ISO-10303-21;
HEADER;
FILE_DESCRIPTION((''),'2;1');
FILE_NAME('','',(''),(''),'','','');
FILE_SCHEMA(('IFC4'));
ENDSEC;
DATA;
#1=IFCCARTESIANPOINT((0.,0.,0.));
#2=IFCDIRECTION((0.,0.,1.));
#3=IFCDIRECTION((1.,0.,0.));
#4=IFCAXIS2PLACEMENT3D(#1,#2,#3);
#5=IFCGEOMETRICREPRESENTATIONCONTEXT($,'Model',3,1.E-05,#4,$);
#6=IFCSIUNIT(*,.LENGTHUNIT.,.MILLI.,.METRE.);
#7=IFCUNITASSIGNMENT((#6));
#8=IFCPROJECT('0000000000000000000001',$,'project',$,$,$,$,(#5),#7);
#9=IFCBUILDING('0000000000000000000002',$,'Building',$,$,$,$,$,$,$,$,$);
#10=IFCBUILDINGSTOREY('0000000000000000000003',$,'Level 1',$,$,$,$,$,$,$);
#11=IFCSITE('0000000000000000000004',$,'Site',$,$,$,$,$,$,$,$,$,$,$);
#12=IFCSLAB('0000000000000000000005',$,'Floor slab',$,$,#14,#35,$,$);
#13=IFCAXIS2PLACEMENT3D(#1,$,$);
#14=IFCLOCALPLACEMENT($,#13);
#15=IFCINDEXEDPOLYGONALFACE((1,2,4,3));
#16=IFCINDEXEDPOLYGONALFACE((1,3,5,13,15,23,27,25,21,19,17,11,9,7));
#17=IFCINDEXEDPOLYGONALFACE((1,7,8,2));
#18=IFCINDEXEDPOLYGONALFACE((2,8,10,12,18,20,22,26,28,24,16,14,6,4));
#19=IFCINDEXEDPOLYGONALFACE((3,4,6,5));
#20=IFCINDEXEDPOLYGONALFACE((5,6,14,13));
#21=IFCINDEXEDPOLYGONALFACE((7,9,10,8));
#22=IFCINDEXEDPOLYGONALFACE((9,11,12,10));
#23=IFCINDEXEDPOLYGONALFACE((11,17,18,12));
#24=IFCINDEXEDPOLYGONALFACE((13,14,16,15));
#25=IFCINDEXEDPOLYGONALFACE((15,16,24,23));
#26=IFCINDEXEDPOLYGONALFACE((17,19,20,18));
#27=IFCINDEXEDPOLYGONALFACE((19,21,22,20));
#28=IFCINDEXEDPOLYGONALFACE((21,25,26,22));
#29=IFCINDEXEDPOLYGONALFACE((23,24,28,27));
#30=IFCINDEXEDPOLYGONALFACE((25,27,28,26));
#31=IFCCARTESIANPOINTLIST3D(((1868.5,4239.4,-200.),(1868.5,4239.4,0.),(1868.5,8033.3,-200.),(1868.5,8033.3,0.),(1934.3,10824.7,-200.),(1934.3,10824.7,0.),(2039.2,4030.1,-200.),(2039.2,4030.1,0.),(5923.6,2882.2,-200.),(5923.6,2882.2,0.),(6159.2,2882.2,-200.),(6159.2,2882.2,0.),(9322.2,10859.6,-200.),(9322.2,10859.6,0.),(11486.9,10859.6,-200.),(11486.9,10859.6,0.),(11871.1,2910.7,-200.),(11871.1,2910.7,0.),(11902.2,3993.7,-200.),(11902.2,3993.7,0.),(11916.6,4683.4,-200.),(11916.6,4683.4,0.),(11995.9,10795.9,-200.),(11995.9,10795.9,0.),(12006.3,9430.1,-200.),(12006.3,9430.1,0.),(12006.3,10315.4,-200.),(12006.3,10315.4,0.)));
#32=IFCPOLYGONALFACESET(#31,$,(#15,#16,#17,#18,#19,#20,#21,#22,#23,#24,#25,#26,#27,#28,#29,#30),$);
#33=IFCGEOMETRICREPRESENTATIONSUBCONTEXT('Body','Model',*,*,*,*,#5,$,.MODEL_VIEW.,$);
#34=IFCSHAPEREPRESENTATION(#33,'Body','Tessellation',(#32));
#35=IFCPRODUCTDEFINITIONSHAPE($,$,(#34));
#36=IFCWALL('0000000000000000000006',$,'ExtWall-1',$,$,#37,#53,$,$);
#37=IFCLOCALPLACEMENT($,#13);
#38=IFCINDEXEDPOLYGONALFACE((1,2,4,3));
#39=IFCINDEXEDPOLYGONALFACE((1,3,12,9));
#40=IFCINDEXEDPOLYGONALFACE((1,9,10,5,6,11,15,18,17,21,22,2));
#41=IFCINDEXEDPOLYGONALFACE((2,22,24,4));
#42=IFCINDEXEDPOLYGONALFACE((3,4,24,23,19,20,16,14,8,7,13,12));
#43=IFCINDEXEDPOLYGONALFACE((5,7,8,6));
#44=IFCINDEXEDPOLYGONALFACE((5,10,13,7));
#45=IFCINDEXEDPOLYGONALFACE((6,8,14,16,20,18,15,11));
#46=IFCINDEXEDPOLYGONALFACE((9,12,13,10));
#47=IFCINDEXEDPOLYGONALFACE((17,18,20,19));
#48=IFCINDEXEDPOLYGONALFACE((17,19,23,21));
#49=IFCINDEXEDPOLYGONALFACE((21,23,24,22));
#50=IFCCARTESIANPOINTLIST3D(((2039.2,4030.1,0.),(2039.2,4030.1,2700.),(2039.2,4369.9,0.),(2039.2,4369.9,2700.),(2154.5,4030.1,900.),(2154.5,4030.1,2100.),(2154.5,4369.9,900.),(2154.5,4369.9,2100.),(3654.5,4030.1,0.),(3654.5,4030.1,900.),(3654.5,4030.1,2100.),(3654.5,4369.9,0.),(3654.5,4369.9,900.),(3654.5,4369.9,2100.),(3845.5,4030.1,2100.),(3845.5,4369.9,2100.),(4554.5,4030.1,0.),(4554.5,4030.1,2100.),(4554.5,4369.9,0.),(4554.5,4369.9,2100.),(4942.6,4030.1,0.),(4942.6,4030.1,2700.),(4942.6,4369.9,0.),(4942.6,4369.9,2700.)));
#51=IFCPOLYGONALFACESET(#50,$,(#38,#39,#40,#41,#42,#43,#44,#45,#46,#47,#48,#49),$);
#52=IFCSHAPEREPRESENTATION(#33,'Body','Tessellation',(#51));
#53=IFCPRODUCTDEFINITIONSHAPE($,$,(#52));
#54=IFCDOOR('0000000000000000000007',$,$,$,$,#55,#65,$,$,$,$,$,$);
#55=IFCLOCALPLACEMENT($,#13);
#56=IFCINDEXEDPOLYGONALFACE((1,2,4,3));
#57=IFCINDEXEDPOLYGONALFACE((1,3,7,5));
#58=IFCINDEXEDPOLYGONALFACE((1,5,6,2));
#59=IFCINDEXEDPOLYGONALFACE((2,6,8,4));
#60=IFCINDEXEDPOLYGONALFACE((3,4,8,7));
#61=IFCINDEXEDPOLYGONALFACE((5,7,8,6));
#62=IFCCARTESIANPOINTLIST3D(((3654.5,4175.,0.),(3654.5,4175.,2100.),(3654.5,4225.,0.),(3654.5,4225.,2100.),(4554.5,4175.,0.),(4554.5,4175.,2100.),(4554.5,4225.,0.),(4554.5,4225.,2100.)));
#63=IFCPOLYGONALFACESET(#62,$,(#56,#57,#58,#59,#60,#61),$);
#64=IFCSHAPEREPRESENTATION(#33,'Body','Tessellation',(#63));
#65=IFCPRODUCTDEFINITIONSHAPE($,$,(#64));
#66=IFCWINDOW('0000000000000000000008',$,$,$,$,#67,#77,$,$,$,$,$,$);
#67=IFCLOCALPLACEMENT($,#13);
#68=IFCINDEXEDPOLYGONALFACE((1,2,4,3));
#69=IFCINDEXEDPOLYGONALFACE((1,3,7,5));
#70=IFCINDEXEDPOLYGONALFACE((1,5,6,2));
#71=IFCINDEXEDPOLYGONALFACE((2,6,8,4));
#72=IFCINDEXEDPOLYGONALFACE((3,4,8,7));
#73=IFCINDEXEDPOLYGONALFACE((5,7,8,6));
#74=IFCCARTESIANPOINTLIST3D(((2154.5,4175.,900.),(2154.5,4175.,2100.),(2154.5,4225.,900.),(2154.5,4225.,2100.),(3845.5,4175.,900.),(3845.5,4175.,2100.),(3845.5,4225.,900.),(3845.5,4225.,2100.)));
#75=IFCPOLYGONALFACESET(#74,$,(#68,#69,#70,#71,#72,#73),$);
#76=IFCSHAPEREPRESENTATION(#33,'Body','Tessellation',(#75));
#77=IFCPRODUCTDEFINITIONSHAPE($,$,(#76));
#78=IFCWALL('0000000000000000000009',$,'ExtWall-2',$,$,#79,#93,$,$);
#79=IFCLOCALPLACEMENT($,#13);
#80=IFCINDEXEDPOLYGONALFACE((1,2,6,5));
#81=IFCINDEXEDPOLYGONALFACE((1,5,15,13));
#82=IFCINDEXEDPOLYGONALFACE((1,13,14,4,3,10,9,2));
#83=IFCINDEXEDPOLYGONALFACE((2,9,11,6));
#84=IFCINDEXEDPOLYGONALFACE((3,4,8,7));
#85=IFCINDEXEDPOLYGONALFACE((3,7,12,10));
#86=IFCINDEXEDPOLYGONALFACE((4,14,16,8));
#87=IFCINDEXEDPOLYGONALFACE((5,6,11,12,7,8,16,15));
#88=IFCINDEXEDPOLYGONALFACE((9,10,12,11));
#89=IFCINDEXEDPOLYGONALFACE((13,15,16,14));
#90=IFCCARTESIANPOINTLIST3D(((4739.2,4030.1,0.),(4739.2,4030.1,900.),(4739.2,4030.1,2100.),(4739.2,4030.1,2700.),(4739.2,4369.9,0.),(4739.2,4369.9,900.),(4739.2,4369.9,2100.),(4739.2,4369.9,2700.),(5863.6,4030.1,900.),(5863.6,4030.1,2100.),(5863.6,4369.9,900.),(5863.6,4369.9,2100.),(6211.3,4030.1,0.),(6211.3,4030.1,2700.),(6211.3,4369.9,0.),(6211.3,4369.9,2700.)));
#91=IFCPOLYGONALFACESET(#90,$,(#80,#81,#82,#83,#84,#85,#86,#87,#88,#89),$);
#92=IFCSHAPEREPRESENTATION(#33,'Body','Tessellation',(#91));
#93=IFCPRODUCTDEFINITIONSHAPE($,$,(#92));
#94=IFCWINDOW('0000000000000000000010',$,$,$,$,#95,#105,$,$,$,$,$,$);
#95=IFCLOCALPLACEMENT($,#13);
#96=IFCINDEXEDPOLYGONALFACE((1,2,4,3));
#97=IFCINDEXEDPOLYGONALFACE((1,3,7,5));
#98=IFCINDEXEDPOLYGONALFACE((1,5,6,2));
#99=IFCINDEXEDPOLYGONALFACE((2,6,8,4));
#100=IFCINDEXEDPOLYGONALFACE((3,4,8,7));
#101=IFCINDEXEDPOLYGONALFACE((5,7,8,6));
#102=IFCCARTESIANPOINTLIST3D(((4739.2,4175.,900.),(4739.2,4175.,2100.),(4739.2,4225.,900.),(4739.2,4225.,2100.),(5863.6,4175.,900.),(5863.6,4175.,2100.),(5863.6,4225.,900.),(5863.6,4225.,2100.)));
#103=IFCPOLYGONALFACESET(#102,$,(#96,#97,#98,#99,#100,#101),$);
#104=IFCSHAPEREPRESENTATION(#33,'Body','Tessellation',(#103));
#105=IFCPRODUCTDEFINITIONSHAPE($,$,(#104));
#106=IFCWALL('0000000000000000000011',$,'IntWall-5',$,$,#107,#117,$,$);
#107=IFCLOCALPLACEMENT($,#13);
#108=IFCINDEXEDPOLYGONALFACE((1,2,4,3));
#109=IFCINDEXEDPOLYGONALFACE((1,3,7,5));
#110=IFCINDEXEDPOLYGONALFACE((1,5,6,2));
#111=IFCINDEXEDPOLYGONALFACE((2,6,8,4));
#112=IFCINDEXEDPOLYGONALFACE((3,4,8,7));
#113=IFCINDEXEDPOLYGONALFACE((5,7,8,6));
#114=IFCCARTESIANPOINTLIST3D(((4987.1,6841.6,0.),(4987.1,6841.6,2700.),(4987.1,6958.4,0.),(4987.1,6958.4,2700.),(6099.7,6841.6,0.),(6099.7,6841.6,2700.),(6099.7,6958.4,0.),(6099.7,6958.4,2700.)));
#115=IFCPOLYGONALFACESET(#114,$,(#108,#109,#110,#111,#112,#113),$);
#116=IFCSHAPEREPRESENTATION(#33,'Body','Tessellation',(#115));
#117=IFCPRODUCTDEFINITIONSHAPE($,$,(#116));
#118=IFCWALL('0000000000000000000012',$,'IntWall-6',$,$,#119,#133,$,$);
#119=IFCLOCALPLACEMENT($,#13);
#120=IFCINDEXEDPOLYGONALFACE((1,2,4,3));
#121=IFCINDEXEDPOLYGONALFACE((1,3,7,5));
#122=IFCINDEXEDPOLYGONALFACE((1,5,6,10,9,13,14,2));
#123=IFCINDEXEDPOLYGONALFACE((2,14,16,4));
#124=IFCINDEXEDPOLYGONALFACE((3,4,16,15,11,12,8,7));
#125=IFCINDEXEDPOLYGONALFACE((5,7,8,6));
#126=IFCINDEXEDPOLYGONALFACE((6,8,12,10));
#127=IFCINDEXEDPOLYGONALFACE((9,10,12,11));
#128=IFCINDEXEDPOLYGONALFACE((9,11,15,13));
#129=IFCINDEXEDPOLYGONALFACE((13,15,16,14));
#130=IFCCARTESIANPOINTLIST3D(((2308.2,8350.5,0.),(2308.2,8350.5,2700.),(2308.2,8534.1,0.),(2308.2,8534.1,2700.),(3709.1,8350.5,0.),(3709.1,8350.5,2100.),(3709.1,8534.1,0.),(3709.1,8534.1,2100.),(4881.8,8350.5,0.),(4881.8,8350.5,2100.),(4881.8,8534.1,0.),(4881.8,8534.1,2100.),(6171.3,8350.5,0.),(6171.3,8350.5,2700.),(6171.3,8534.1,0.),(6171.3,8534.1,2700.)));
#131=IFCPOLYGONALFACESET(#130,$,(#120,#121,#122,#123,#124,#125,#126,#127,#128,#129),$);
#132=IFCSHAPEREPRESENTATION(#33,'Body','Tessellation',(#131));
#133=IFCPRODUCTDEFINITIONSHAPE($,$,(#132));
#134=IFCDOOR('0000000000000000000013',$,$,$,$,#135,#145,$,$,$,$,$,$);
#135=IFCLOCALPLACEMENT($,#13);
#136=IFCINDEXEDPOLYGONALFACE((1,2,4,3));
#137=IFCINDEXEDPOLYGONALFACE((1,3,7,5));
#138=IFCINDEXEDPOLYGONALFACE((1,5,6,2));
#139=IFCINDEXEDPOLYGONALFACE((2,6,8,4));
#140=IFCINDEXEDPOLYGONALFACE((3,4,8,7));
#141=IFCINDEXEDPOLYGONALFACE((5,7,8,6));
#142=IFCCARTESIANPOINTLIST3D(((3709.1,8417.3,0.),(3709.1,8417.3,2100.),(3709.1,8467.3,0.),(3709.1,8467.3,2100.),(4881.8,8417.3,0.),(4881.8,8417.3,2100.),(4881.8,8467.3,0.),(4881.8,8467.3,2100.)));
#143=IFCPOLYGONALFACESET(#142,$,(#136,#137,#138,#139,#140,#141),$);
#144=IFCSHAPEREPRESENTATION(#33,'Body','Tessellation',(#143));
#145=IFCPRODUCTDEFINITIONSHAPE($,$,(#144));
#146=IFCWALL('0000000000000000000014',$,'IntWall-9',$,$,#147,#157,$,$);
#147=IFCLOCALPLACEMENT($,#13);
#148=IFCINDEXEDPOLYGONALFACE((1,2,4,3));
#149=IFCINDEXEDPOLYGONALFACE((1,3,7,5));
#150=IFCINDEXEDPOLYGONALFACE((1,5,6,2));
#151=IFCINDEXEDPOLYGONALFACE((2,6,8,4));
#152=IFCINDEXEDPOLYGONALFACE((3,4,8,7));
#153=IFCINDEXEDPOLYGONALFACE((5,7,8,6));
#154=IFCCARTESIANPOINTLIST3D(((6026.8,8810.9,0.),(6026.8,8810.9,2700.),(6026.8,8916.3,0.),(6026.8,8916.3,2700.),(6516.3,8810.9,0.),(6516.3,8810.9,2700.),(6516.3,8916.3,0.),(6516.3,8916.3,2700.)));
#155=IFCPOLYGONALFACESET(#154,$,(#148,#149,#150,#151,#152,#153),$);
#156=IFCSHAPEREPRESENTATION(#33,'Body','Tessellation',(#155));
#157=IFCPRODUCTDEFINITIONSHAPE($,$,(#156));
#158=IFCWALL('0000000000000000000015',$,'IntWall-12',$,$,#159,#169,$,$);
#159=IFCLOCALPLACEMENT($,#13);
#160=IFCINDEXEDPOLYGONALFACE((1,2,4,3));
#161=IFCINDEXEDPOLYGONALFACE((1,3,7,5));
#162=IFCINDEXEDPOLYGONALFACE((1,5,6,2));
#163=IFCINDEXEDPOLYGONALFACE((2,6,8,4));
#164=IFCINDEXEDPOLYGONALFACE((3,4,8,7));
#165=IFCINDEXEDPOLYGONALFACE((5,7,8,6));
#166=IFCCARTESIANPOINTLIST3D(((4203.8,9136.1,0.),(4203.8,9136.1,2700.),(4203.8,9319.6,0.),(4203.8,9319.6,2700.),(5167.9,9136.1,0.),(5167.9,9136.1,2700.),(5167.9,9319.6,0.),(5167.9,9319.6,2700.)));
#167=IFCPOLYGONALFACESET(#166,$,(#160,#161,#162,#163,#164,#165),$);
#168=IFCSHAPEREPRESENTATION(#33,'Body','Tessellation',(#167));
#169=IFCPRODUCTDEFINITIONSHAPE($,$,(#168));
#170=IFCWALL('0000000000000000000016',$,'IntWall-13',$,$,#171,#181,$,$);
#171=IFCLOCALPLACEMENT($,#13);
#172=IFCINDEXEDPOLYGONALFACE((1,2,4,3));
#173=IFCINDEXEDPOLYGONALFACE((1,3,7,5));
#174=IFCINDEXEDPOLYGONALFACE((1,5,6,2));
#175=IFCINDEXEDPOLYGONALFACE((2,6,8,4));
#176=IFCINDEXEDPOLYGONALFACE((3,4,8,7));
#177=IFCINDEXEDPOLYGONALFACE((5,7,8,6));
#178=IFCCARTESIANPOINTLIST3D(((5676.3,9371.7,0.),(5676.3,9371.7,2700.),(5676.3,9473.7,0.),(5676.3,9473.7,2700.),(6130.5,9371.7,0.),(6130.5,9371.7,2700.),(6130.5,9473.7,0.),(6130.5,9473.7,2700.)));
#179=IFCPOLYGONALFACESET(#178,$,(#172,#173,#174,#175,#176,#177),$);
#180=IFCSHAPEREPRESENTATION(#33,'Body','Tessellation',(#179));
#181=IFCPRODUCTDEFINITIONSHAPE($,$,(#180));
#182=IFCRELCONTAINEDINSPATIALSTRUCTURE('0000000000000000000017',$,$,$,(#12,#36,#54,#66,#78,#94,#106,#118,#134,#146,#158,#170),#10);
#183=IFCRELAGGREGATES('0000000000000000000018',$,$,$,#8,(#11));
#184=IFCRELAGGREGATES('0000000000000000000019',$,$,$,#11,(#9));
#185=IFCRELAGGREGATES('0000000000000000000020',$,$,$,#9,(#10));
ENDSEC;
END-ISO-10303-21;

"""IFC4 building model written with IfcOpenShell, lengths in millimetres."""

from ifc_helpers import new_model, si_unit, frame, origin_with_axes, place, context, subcontext, project, spatial, indexed_curve, outline, extrude, element, fill, save


model = new_model("IFC4")

# Units and contexts
model_context = context("Model", 3, precision=1e-05, world=origin_with_axes())
body_context = subcontext(model_context, "Body", "Model", "MODEL_VIEW")
ifc_project = project(units=[si_unit("LENGTHUNIT", "METRE", prefix="MILLI")], contexts=[model_context])

# Site, building, storey
site = spatial("IfcSite", under=ifc_project, Name="Site")
building = spatial("IfcBuilding", under=site, Name="Building")
storey = spatial("IfcBuildingStorey", under=building, Name="Level 1")

# Slab
slab_placement = place(None, frame((0.0, 0.0, -200.0), z_axis=(0.0, 0.0, 1.0), x_axis=(1.0, 0.0, 0.0)))
element("IfcSlab", 1, at=slab_placement, inside=storey, Name="Floor slab", context=body_context, shape_type="SweptSolid", body=[
    extrude(outline(indexed_curve([(5923.6, 2882.2), (2039.2, 4030.1), (1868.5, 4239.4), (1868.5, 8033.3), (1934.3, 10824.7), (9322.2, 10859.6), (11486.9, 10859.6), (11995.9, 10795.9), (12006.3, 10315.4), (12006.3, 9430.1), (11916.6, 4683.4), (11902.2, 3993.7), (11871.1, 2910.7), (6159.2, 2882.2)])), None, (0.0, 0.0, 1.0), 200.0),
])

# Wall, openings, door, window
wall_1_placement = place(None, frame((2039.2, 4200.0, 0.0), z_axis=(0.0, 0.0, 1.0), x_axis=(1.0, 0.0, 0.0)))
wall_1 = element("IfcWall", 2, at=wall_1_placement, inside=storey, Name="ExtWall-1", context=body_context, shape_type="SweptSolid", body=[
    extrude(outline(indexed_curve([(0.0, 0.0), (0.0, 339.8), (2903.5, 339.8), (2903.5, 0.0), (0.0, 0.0)], self_intersect=False)), frame((0.0, -169.9, 0.0), z_axis=(0.0, 0.0, 1.0), x_axis=(1.0, 0.0, 0.0)), (0.0, 0.0, 1.0), 2700.0),
])
opening_1_placement = place(wall_1_placement, frame((1615.4, 0.0, 0.0), z_axis=(0.0, 0.0, 1.0), x_axis=(1.0, 0.0, 0.0)))
opening_1 = element("IfcOpeningElement", 3, at=opening_1_placement, cuts=wall_1, context=body_context, shape_type="SweptSolid", body=[
    extrude(outline(indexed_curve([(0.0, 0.0), (0.0, 439.8), (900.0, 439.8), (900.0, 0.0), (0.0, 0.0)], self_intersect=False)), frame((0.0, -219.9, 0.0), z_axis=(0.0, 0.0, 1.0), x_axis=(1.0, 0.0, 0.0)), (0.0, 0.0, 1.0), 2100.0),
])
opening_2_placement = place(wall_1_placement, frame((115.4, 0.0, 900.0), z_axis=(0.0, 0.0, 1.0), x_axis=(1.0, 0.0, 0.0)))
opening_2 = element("IfcOpeningElement", 4, at=opening_2_placement, cuts=wall_1, context=body_context, shape_type="SweptSolid", body=[
    extrude(outline(indexed_curve([(0.0, 0.0), (0.0, 439.8), (1690.9, 439.8), (1690.9, 0.0), (0.0, 0.0)], self_intersect=False)), frame((0.0, -219.9, 0.0), z_axis=(0.0, 0.0, 1.0), x_axis=(1.0, 0.0, 0.0)), (0.0, 0.0, 1.0), 1200.0),
])
door_1_placement = place(opening_1_placement, origin_with_axes())
door_1 = element("IfcDoor", 5, at=door_1_placement, inside=storey, context=body_context, shape_type="SweptSolid", body=[
    extrude(outline(indexed_curve([(0.0, 0.0), (0.0, 50.0), (900.0, 50.0), (900.0, 0.0), (0.0, 0.0)], self_intersect=False)), frame((0.0, -25.0, 0.0), z_axis=(0.0, 0.0, 1.0), x_axis=(1.0, 0.0, 0.0)), (0.0, 0.0, 1.0), 2100.0),
])
fill(opening_1, door_1)
window_1_placement = place(opening_2_placement, frame((0.0, 0.0, 0.0), z_axis=(0.0, 0.0, 1.0), x_axis=(1.0, 0.0, 0.0)))
window_1 = element("IfcWindow", 6, at=window_1_placement, inside=storey, context=body_context, shape_type="SweptSolid", body=[
    extrude(outline(indexed_curve([(0.0, 0.0), (0.0, 50.0), (1690.9, 50.0), (1690.9, 0.0), (0.0, 0.0)], self_intersect=False)), frame((0.0, -25.0, 0.0), z_axis=(0.0, 0.0, 1.0), x_axis=(1.0, 0.0, 0.0)), (0.0, 0.0, 1.0), 1200.0),
])
fill(opening_2, window_1)

# Wall, opening, window
wall_2_placement = place(None, frame((4739.2, 4200.0, 0.0), z_axis=(0.0, 0.0, 1.0), x_axis=(1.0, 0.0, 0.0)))
wall_2 = element("IfcWall", 7, at=wall_2_placement, inside=storey, Name="ExtWall-2", context=body_context, shape_type="SweptSolid", body=[
    extrude(outline(indexed_curve([(0.0, 0.0), (0.0, 339.8), (1472.1, 339.8), (1472.1, 0.0), (0.0, 0.0)], self_intersect=False)), frame((0.0, -169.9, 0.0), z_axis=(0.0, 0.0, 1.0), x_axis=(1.0, 0.0, 0.0)), (0.0, 0.0, 1.0), 2700.0),
])
opening_3_placement = place(wall_2_placement, frame((0.0, 0.0, 900.0), z_axis=(0.0, 0.0, 1.0), x_axis=(1.0, 0.0, 0.0)))
opening_3 = element("IfcOpeningElement", 8, at=opening_3_placement, cuts=wall_2, context=body_context, shape_type="SweptSolid", body=[
    extrude(outline(indexed_curve([(0.0, 0.0), (0.0, 439.8), (1124.5, 439.8), (1124.5, 0.0), (0.0, 0.0)], self_intersect=False)), frame((0.0, -219.9, 0.0), z_axis=(0.0, 0.0, 1.0), x_axis=(1.0, 0.0, 0.0)), (0.0, 0.0, 1.0), 1200.0),
])
window_2_placement = place(opening_3_placement, origin_with_axes())
window_2 = element("IfcWindow", 9, at=window_2_placement, inside=storey, context=body_context, shape_type="SweptSolid", body=[
    extrude(outline(indexed_curve([(0.0, 0.0), (0.0, 50.0), (1124.5, 50.0), (1124.5, 0.0), (0.0, 0.0)], self_intersect=False)), frame((0.0, -25.0, 0.0), z_axis=(0.0, 0.0, 1.0), x_axis=(1.0, 0.0, 0.0)), (0.0, 0.0, 1.0), 1200.0),
])
fill(opening_3, window_2)

# Wall
wall_3_placement = place(None, frame((4987.1, 6900.0, 0.0), z_axis=(0.0, 0.0, 1.0), x_axis=(1.0, 0.0, 0.0)))
element("IfcWall", 10, at=wall_3_placement, inside=storey, Name="IntWall-5", context=body_context, shape_type="SweptSolid", body=[
    extrude(outline(indexed_curve([(0.0, 0.0), (0.0, 116.7), (1112.6, 116.7), (1112.6, 0.0), (0.0, 0.0)], self_intersect=False)), frame((0.0, -58.4, 0.0), z_axis=(0.0, 0.0, 1.0), x_axis=(1.0, 0.0, 0.0)), (0.0, 0.0, 1.0), 2700.0),
])

# Wall, opening, door
wall_4_placement = place(None, frame((2308.2, 8442.3, 0.0), z_axis=(0.0, 0.0, 1.0), x_axis=(1.0, 0.0, 0.0)))
wall_4 = element("IfcWall", 11, at=wall_4_placement, inside=storey, Name="IntWall-6", context=body_context, shape_type="SweptSolid", body=[
    extrude(outline(indexed_curve([(0.0, 0.0), (0.0, 183.5), (3863.1, 183.5), (3863.1, 0.0), (0.0, 0.0)], self_intersect=False)), frame((0.0, -91.8, 0.0), z_axis=(0.0, 0.0, 1.0), x_axis=(1.0, 0.0, 0.0)), (0.0, 0.0, 1.0), 2700.0),
])
opening_4_placement = place(wall_4_placement, frame((1400.9, 0.0, 0.0), z_axis=(0.0, 0.0, 1.0), x_axis=(1.0, 0.0, 0.0)))
opening_4 = element("IfcOpeningElement", 12, at=opening_4_placement, cuts=wall_4, context=body_context, shape_type="SweptSolid", body=[
    extrude(outline(indexed_curve([(0.0, 0.0), (0.0, 283.5), (1172.7, 283.5), (1172.7, 0.0), (0.0, 0.0)], self_intersect=False)), frame((0.0, -141.8, 0.0), z_axis=(0.0, 0.0, 1.0), x_axis=(1.0, 0.0, 0.0)), (0.0, 0.0, 1.0), 2100.0),
])
door_2_placement = place(opening_4_placement, origin_with_axes())
door_2 = element("IfcDoor", 13, at=door_2_placement, inside=storey, context=body_context, shape_type="SweptSolid", body=[
    extrude(outline(indexed_curve([(0.0, 0.0), (0.0, 50.0), (1172.7, 50.0), (1172.7, 0.0), (0.0, 0.0)], self_intersect=False)), frame((0.0, -25.0, 0.0), z_axis=(0.0, 0.0, 1.0), x_axis=(1.0, 0.0, 0.0)), (0.0, 0.0, 1.0), 2100.0),
])
fill(opening_4, door_2)

# Walls
wall_5_placement = place(None, frame((6026.8, 8863.6, 0.0), z_axis=(0.0, 0.0, 1.0), x_axis=(1.0, 0.0, 0.0)))
element("IfcWall", 14, at=wall_5_placement, inside=storey, Name="IntWall-9", context=body_context, shape_type="SweptSolid", body=[
    extrude(outline(indexed_curve([(0.0, 0.0), (0.0, 105.4), (489.5, 105.4), (489.5, 0.0), (0.0, 0.0)], self_intersect=False)), frame((0.0, -52.7, 0.0), z_axis=(0.0, 0.0, 1.0), x_axis=(1.0, 0.0, 0.0)), (0.0, 0.0, 1.0), 2700.0),
])
wall_6_placement = place(None, frame((4203.8, 9227.8, 0.0), z_axis=(0.0, 0.0, 1.0), x_axis=(1.0, 0.0, 0.0)))
element("IfcWall", 15, at=wall_6_placement, inside=storey, Name="IntWall-12", context=body_context, shape_type="SweptSolid", body=[
    extrude(outline(indexed_curve([(0.0, 0.0), (0.0, 183.5), (964.1, 183.5), (964.1, 0.0), (0.0, 0.0)], self_intersect=False)), frame((0.0, -91.8, 0.0), z_axis=(0.0, 0.0, 1.0), x_axis=(1.0, 0.0, 0.0)), (0.0, 0.0, 1.0), 2700.0),
])
wall_7_placement = place(None, frame((5676.3, 9422.7, 0.0), z_axis=(0.0, 0.0, 1.0), x_axis=(1.0, 0.0, 0.0)))
element("IfcWall", 16, at=wall_7_placement, inside=storey, Name="IntWall-13", context=body_context, shape_type="SweptSolid", body=[
    extrude(outline(indexed_curve([(0.0, 0.0), (0.0, 102.0), (454.2, 102.0), (454.2, 0.0), (0.0, 0.0)], self_intersect=False)), frame((0.0, -51.0, 0.0), z_axis=(0.0, 0.0, 1.0), x_axis=(1.0, 0.0, 0.0)), (0.0, 0.0, 1.0), 2700.0),
])

save(model, "model.ifc")
